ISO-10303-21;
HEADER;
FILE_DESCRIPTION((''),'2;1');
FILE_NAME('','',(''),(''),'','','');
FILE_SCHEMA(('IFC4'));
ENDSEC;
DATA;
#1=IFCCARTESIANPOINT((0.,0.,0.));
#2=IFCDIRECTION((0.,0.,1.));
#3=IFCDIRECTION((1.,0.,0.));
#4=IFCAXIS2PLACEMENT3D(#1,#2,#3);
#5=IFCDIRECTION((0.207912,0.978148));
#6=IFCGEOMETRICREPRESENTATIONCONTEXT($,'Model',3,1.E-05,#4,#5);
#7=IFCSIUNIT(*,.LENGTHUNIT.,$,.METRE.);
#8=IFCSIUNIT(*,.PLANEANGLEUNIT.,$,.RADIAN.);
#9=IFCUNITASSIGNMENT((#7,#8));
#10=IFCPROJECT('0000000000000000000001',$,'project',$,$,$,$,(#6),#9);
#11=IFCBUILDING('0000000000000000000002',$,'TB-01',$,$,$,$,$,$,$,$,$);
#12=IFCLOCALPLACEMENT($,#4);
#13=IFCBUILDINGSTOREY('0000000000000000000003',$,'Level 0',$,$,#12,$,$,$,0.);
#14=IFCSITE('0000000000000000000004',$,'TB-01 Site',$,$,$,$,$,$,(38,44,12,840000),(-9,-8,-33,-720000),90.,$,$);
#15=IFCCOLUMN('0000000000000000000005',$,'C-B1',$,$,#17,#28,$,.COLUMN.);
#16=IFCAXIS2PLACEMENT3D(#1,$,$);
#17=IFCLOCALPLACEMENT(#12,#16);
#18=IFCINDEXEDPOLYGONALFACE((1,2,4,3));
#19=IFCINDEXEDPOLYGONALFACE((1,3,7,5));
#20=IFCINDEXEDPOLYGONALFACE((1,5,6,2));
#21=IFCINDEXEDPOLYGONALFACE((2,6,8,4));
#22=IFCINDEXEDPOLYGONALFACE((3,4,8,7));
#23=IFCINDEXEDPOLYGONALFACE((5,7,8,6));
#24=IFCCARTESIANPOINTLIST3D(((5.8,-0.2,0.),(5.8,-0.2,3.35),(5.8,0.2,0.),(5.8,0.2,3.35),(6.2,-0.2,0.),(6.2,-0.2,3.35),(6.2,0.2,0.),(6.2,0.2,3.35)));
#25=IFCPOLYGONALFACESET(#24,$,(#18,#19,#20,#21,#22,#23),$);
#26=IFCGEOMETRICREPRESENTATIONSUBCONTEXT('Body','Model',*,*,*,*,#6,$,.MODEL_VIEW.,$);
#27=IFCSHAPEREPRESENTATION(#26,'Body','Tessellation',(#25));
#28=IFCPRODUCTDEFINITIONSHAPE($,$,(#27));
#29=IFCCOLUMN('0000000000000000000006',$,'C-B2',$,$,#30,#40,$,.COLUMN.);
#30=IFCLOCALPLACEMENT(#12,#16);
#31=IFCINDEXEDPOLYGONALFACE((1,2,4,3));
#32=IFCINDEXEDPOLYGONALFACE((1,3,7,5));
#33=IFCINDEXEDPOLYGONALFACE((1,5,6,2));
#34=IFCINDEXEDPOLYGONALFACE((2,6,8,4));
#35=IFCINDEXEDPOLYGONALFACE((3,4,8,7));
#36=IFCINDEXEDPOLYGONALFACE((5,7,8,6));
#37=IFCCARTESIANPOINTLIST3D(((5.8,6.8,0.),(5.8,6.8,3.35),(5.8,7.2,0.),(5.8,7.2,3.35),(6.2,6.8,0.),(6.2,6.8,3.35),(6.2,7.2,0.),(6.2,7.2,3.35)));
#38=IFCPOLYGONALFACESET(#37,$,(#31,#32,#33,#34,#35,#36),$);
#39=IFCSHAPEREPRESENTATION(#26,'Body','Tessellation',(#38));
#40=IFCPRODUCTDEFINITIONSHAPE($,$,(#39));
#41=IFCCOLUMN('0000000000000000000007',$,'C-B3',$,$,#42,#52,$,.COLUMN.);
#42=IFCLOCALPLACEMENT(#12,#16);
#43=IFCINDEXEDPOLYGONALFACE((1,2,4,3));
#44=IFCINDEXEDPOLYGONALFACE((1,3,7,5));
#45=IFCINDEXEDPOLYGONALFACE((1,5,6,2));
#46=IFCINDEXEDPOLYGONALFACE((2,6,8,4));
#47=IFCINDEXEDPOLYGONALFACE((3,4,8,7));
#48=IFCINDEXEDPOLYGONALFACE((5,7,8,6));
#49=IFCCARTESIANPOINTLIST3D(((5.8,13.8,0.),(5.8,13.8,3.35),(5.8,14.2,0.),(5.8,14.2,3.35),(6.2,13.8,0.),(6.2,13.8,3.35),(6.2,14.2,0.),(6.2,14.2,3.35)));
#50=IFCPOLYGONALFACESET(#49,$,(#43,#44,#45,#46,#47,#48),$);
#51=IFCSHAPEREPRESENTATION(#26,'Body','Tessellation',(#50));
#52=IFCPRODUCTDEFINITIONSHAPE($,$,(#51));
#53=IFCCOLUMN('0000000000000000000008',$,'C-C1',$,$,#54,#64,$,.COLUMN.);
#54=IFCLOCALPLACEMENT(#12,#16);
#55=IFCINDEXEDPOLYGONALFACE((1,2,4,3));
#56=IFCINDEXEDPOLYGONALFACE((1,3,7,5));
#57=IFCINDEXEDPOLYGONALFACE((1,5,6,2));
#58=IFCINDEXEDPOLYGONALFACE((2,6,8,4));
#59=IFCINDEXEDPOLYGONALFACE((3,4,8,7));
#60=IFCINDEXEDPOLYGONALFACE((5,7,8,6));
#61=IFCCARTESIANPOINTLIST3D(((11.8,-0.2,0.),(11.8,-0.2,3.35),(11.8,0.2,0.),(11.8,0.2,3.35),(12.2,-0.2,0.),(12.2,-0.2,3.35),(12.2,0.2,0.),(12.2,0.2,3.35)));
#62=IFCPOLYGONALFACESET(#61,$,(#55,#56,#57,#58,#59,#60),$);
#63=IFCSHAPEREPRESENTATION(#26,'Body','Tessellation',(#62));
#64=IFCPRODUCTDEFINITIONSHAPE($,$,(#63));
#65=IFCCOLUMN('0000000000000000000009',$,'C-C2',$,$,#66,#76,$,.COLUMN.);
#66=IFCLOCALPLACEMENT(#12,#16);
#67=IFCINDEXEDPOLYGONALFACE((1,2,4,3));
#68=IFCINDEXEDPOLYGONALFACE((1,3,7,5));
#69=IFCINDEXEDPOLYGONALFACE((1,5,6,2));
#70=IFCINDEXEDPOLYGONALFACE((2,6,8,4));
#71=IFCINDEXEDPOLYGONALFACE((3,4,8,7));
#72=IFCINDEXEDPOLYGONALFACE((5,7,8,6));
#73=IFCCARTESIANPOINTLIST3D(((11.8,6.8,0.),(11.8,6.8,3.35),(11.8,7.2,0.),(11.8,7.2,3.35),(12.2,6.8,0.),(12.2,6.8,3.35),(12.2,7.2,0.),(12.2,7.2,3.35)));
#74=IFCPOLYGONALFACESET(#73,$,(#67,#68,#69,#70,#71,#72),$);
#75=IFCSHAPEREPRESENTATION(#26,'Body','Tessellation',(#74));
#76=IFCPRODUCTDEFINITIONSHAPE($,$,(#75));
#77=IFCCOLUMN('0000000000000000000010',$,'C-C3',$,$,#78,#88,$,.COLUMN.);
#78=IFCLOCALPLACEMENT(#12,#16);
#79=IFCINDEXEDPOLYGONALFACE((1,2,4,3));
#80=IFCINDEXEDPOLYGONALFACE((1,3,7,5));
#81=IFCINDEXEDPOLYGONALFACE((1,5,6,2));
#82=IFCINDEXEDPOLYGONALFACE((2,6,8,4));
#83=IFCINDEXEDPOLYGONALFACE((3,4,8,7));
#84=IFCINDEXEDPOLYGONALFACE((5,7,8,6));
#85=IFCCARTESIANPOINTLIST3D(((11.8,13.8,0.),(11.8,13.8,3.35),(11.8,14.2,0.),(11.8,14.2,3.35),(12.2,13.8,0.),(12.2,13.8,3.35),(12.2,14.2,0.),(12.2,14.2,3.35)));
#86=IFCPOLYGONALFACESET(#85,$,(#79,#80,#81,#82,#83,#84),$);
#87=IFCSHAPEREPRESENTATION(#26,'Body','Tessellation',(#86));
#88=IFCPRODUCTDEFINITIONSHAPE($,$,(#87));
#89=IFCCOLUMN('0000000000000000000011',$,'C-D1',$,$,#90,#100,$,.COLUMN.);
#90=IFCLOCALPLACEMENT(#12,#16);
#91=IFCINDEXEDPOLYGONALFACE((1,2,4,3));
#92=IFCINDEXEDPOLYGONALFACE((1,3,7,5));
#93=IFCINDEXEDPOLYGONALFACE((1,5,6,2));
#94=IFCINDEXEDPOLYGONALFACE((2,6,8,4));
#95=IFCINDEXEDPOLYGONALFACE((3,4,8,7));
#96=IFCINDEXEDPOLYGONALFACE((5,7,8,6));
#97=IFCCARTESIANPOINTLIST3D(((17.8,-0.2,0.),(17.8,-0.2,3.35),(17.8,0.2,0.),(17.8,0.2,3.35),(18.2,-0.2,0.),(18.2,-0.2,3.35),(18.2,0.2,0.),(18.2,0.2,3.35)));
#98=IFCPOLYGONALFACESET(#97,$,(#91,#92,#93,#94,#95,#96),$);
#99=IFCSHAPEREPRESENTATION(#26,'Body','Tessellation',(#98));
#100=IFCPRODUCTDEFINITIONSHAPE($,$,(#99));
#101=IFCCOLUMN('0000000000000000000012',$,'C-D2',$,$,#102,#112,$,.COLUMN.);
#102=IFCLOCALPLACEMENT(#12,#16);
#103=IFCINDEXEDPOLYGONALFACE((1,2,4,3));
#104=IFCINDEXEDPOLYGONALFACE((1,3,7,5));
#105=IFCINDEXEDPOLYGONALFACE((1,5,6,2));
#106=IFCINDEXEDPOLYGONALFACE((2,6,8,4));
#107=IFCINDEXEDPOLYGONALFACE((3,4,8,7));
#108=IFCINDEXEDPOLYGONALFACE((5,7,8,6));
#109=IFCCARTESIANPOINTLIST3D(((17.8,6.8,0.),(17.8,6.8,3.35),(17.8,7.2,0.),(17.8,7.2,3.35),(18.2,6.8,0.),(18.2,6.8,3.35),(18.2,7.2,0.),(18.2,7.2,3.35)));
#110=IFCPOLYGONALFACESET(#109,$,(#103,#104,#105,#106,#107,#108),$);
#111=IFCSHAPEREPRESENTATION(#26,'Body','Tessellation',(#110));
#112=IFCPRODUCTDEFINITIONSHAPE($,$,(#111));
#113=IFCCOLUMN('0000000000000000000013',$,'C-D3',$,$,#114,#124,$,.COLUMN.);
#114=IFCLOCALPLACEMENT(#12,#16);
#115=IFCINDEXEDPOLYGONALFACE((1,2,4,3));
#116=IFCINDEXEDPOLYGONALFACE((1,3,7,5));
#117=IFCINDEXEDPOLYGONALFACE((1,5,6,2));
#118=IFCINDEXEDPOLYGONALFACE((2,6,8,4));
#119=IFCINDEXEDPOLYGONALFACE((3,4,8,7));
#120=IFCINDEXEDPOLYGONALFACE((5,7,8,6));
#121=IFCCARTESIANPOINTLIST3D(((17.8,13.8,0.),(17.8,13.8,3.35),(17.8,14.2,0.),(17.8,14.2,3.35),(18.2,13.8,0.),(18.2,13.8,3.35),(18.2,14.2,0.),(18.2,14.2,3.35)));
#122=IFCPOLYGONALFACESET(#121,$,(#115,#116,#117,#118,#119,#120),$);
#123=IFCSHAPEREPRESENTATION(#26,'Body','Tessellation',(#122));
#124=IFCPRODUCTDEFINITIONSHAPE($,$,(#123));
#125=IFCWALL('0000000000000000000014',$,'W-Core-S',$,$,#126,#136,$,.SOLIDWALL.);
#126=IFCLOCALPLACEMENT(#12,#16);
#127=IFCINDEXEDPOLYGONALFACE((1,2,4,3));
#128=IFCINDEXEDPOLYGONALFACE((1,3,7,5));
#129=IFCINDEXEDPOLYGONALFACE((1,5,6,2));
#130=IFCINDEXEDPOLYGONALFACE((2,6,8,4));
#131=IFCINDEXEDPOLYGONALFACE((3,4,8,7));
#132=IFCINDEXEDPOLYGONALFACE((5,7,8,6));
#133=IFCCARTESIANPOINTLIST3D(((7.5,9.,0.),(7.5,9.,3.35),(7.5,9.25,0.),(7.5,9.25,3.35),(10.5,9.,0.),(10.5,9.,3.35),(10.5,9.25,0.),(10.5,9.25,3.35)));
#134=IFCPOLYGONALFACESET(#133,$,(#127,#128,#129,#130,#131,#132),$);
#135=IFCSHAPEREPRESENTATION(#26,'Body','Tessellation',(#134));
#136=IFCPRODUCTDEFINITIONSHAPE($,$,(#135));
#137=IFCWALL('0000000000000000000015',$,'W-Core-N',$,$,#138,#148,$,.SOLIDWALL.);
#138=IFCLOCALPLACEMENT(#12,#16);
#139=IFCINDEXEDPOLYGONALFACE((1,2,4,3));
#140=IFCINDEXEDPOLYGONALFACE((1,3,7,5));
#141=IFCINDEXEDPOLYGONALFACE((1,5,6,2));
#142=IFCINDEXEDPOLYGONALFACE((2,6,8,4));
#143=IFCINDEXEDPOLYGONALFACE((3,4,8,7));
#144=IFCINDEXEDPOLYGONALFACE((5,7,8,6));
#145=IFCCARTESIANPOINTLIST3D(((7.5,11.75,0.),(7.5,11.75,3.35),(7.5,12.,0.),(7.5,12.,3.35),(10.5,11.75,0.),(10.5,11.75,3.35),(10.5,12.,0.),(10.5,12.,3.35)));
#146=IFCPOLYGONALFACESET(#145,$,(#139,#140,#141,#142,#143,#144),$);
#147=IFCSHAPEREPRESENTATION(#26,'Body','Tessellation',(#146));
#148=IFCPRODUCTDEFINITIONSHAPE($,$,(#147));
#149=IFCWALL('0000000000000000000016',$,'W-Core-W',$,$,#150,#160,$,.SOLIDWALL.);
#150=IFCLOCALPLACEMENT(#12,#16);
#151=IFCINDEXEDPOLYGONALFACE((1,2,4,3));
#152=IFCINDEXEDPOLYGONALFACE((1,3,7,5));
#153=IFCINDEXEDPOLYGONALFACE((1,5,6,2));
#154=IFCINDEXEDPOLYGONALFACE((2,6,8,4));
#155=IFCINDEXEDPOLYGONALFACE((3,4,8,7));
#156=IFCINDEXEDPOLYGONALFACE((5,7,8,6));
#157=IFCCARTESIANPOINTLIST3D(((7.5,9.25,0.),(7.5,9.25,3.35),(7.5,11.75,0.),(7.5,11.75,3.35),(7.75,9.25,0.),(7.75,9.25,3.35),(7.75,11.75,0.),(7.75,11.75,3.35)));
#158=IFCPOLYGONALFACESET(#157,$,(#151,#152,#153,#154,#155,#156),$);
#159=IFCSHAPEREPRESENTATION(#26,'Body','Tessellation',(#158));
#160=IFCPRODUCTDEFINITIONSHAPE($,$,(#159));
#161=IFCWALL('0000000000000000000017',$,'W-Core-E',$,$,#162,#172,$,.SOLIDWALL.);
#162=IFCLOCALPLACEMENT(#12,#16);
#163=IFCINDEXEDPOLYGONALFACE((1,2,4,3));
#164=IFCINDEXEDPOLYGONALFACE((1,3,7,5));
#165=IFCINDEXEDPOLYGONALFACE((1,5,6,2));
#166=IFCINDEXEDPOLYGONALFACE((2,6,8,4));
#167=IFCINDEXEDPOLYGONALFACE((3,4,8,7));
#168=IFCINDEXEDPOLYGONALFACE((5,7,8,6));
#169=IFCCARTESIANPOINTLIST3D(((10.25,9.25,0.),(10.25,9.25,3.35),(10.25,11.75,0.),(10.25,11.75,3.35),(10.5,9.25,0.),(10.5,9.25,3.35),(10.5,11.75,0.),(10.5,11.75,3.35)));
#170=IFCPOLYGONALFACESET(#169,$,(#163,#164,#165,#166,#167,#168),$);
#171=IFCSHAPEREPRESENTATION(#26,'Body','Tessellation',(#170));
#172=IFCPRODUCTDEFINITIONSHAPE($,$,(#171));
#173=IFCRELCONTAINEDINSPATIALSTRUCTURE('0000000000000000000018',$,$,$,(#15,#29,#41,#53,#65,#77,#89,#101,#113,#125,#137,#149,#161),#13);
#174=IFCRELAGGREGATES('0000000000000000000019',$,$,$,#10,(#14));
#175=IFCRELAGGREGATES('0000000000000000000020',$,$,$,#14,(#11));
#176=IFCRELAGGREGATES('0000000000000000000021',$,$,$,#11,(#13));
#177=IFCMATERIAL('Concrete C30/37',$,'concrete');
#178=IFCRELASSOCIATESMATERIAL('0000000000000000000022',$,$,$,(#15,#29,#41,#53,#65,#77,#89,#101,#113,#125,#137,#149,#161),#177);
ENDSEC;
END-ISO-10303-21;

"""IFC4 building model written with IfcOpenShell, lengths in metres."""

from ifc_helpers import new_model, si_unit, direction, frame, origin_with_axes, place, context, subcontext, project, spatial, rectangle, extrude, material, element, save


model = new_model("IFC4")

# Units and contexts
model_context = context("Model", 3, precision=1e-05, world=origin_with_axes(), true_north=direction((0.207912, 0.978148)))
body_context = subcontext(model_context, "Body", "Model", "MODEL_VIEW")
ifc_project = project(units=[si_unit("LENGTHUNIT", "METRE"), si_unit("PLANEANGLEUNIT", "RADIAN")], contexts=[model_context])

# Site, building, storey
site = spatial("IfcSite", under=ifc_project, Name="TB-01 Site", RefLatitude=(38, 44, 12, 840000), RefLongitude=(-9, -8, -33, -720000), RefElevation=90.0)
building = spatial("IfcBuilding", under=site, Name="TB-01")
storey_placement = place(None, origin_with_axes())
storey = spatial("IfcBuildingStorey", under=building, at=storey_placement, Name="Level 0", Elevation=0.0)

# Columns
ifc_material_1 = material(Name="Concrete C30/37", Category="concrete")
column_1_placement = place(storey_placement, frame((6.0, 0.0, 0.0), z_axis=(0.0, 0.0, 1.0), x_axis=(1.0, 0.0, 0.0)))
element("IfcColumn", 1, at=column_1_placement, inside=storey, material=ifc_material_1, Name="C-B1", PredefinedType="COLUMN", context=body_context, shape_type="SweptSolid", body=[
    extrude(rectangle(XDim=0.4, YDim=0.4), origin_with_axes(), (0.0, 0.0, 1.0), 3.35),
])
column_2_placement = place(storey_placement, frame((6.0, 7.0, 0.0), z_axis=(0.0, 0.0, 1.0), x_axis=(1.0, 0.0, 0.0)))
element("IfcColumn", 2, at=column_2_placement, inside=storey, material=ifc_material_1, Name="C-B2", PredefinedType="COLUMN", context=body_context, shape_type="SweptSolid", body=[
    extrude(rectangle(XDim=0.4, YDim=0.4), origin_with_axes(), (0.0, 0.0, 1.0), 3.35),
])
column_3_placement = place(storey_placement, frame((6.0, 14.0, 0.0), z_axis=(0.0, 0.0, 1.0), x_axis=(1.0, 0.0, 0.0)))
element("IfcColumn", 3, at=column_3_placement, inside=storey, material=ifc_material_1, Name="C-B3", PredefinedType="COLUMN", context=body_context, shape_type="SweptSolid", body=[
    extrude(rectangle(XDim=0.4, YDim=0.4), origin_with_axes(), (0.0, 0.0, 1.0), 3.35),
])
column_4_placement = place(storey_placement, frame((12.0, 0.0, 0.0), z_axis=(0.0, 0.0, 1.0), x_axis=(1.0, 0.0, 0.0)))
element("IfcColumn", 4, at=column_4_placement, inside=storey, material=ifc_material_1, Name="C-C1", PredefinedType="COLUMN", context=body_context, shape_type="SweptSolid", body=[
    extrude(rectangle(XDim=0.4, YDim=0.4), origin_with_axes(), (0.0, 0.0, 1.0), 3.35),
])
column_5_placement = place(storey_placement, frame((12.0, 7.0, 0.0), z_axis=(0.0, 0.0, 1.0), x_axis=(1.0, 0.0, 0.0)))
element("IfcColumn", 5, at=column_5_placement, inside=storey, material=ifc_material_1, Name="C-C2", PredefinedType="COLUMN", context=body_context, shape_type="SweptSolid", body=[
    extrude(rectangle(XDim=0.4, YDim=0.4), origin_with_axes(), (0.0, 0.0, 1.0), 3.35),
])
column_6_placement = place(storey_placement, frame((12.0, 14.0, 0.0), z_axis=(0.0, 0.0, 1.0), x_axis=(1.0, 0.0, 0.0)))
element("IfcColumn", 6, at=column_6_placement, inside=storey, material=ifc_material_1, Name="C-C3", PredefinedType="COLUMN", context=body_context, shape_type="SweptSolid", body=[
    extrude(rectangle(XDim=0.4, YDim=0.4), origin_with_axes(), (0.0, 0.0, 1.0), 3.35),
])
column_7_placement = place(storey_placement, frame((18.0, 0.0, 0.0), z_axis=(0.0, 0.0, 1.0), x_axis=(1.0, 0.0, 0.0)))
element("IfcColumn", 7, at=column_7_placement, inside=storey, material=ifc_material_1, Name="C-D1", PredefinedType="COLUMN", context=body_context, shape_type="SweptSolid", body=[
    extrude(rectangle(XDim=0.4, YDim=0.4), origin_with_axes(), (0.0, 0.0, 1.0), 3.35),
])
column_8_placement = place(storey_placement, frame((18.0, 7.0, 0.0), z_axis=(0.0, 0.0, 1.0), x_axis=(1.0, 0.0, 0.0)))
element("IfcColumn", 8, at=column_8_placement, inside=storey, material=ifc_material_1, Name="C-D2", PredefinedType="COLUMN", context=body_context, shape_type="SweptSolid", body=[
    extrude(rectangle(XDim=0.4, YDim=0.4), origin_with_axes(), (0.0, 0.0, 1.0), 3.35),
])
column_9_placement = place(storey_placement, frame((18.0, 14.0, 0.0), z_axis=(0.0, 0.0, 1.0), x_axis=(1.0, 0.0, 0.0)))
element("IfcColumn", 9, at=column_9_placement, inside=storey, material=ifc_material_1, Name="C-D3", PredefinedType="COLUMN", context=body_context, shape_type="SweptSolid", body=[
    extrude(rectangle(XDim=0.4, YDim=0.4), origin_with_axes(), (0.0, 0.0, 1.0), 3.35),
])

# Walls
for number, where, z_axis, x_axis, name in (
    (10, (9.0, 9.125, 0.0), (0.0, 0.0, 1.0), (1.0, 0.0, 0.0), "W-Core-S"),
    (11, (9.0, 11.875, 0.0), (0.0, 0.0, 1.0), (1.0, 0.0, 0.0), "W-Core-N"),
):
    element("IfcWall", number, at=place(storey_placement, frame(where, z_axis=z_axis, x_axis=x_axis)), inside=storey, material=ifc_material_1, Name=name, PredefinedType="SOLIDWALL", context=body_context, shape_type="SweptSolid", body=[
        extrude(rectangle(XDim=3.0, YDim=0.25), origin_with_axes(), (0.0, 0.0, 1.0), 3.35),
    ])
for number, where, z_axis, x_axis, name in (
    (12, (7.625, 10.5, 0.0), (0.0, 0.0, 1.0), (1.0, 0.0, 0.0), "W-Core-W"),
    (13, (10.375, 10.5, 0.0), (0.0, 0.0, 1.0), (1.0, 0.0, 0.0), "W-Core-E"),
):
    element("IfcWall", number, at=place(storey_placement, frame(where, z_axis=z_axis, x_axis=x_axis)), inside=storey, material=ifc_material_1, Name=name, PredefinedType="SOLIDWALL", context=body_context, shape_type="SweptSolid", body=[
        extrude(rectangle(XDim=0.25, YDim=2.5), origin_with_axes(), (0.0, 0.0, 1.0), 3.35),
    ])

save(model, "model.ifc")
